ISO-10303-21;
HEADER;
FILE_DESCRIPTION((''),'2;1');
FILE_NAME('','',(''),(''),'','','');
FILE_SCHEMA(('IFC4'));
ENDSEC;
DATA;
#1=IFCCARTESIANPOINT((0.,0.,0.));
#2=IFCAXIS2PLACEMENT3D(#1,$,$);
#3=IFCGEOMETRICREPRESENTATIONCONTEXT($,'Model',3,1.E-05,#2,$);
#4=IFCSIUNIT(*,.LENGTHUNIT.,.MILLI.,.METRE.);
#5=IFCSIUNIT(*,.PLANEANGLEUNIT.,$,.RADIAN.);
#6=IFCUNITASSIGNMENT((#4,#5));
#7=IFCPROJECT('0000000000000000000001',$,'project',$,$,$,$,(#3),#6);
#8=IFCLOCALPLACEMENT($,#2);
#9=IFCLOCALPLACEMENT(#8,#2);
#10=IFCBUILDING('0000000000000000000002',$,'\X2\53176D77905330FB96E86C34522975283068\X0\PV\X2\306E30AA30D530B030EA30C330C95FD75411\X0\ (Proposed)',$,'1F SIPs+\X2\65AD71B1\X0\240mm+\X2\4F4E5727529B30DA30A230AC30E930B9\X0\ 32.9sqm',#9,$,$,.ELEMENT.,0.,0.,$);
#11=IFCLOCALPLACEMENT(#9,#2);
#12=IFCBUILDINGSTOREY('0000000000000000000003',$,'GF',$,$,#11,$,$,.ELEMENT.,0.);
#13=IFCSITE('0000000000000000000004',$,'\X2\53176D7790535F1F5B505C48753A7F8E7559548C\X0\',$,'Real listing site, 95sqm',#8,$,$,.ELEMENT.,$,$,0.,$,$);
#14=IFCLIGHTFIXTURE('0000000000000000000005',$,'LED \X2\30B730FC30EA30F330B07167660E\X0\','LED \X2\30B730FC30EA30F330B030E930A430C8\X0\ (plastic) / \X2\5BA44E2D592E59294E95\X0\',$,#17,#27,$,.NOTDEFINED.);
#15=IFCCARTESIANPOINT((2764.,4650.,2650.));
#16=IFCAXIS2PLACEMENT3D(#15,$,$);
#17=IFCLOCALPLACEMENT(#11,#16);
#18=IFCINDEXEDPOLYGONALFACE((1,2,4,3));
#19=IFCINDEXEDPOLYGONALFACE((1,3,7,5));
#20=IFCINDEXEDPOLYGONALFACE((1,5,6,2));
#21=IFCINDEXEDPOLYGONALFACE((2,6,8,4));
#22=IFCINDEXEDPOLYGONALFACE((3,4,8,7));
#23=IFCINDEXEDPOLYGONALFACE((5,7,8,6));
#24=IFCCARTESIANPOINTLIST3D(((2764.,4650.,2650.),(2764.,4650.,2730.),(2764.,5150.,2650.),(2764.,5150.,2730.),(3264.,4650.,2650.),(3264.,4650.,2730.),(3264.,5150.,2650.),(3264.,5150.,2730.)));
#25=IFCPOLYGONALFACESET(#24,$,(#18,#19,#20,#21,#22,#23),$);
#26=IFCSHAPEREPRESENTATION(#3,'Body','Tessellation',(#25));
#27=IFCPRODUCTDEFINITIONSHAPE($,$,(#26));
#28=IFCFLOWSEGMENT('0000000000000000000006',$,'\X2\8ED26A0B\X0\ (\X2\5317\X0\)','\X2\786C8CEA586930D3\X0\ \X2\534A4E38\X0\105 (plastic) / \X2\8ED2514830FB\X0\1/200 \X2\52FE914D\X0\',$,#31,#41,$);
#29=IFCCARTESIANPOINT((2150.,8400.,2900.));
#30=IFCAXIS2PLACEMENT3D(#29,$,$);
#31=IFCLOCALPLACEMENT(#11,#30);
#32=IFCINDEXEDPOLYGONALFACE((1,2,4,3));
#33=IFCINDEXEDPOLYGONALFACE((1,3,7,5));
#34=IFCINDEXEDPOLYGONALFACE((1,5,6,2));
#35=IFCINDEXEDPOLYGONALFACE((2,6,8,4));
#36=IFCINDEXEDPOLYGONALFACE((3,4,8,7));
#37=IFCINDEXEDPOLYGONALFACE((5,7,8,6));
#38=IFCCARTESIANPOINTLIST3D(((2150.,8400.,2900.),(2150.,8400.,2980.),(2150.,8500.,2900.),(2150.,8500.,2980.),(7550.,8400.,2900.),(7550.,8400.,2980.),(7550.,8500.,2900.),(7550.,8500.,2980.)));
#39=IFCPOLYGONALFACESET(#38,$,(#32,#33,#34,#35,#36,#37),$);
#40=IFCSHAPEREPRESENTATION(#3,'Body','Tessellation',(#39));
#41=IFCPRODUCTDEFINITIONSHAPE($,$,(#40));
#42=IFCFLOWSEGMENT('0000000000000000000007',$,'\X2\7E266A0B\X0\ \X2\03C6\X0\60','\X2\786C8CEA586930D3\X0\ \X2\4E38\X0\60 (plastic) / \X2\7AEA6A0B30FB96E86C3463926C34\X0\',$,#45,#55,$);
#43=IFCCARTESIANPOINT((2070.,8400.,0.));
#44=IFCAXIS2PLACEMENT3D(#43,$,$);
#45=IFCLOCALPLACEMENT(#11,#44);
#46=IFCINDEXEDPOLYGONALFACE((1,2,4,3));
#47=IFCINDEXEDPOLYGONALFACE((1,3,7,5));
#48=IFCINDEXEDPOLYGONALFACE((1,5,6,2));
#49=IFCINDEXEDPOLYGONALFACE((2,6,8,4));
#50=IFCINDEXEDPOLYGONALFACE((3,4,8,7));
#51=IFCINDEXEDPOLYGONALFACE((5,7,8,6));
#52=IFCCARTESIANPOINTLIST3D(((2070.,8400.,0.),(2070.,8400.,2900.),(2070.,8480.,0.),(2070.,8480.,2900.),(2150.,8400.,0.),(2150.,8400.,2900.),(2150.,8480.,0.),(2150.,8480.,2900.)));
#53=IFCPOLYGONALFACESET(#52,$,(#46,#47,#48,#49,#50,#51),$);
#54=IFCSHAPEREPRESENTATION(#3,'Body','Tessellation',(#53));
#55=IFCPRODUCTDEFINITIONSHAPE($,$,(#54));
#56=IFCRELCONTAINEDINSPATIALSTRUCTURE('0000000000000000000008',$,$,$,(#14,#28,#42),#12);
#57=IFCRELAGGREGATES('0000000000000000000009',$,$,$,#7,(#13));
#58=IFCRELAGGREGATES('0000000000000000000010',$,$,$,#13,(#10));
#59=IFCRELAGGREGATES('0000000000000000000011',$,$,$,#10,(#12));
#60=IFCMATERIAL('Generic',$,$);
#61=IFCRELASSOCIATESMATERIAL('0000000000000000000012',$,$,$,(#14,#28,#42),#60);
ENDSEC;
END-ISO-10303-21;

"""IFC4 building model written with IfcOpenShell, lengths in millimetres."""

from ifc_helpers import new_model, si_unit, frame, frame_2d, origin, place, context, project, spatial, rectangle, extrude, material, element, save


model = new_model("IFC4")

# Units and contexts
model_context = context("Model", 3, precision=1e-05, world=origin())
ifc_project = project(units=[si_unit("LENGTHUNIT", "METRE", prefix="MILLI"), si_unit("PLANEANGLEUNIT", "RADIAN")], contexts=[model_context])

# Site, building, storey
site_placement = place(None, origin())
site = spatial("IfcSite", under=ifc_project, at=site_placement, Name="北海道弟子屈町美留和", ObjectType="Real listing site, 95sqm", CompositionType="ELEMENT", RefElevation=0.0)
building_placement = place(site_placement, origin())
building = spatial("IfcBuilding", under=site, at=building_placement, Name="北海道・雨水利用とPVのオフグリッド志向 (Proposed)", ObjectType="1F SIPs+断熱240mm+低圧力ペアガラス 32.9sqm", CompositionType="ELEMENT", ElevationOfRefHeight=0.0, ElevationOfTerrain=0.0)
storey_placement = place(building_placement, origin())
storey = spatial("IfcBuildingStorey", under=building, at=storey_placement, Name="GF", CompositionType="ELEMENT", Elevation=0.0)

# Shared definitions
ifc_material_1 = material(Name="Generic")

# Light fixture
light_fixture_placement = place(storey_placement, frame((2764.0, 4650.0, 2650.0)))
element("IfcLightFixture", 1, at=light_fixture_placement, inside=storey, material=ifc_material_1, Name="LED シーリング照明", Description="LED シーリングライト (plastic) / 室中央天井", PredefinedType="NOTDEFINED", context=model_context, shape_type="SweptSolid", body=[
    extrude(rectangle(XDim=500.0, YDim=500.0, at=frame_2d((250.0, 250.0))), frame((2764.0, 4650.0, 2650.0)), (0.0, 0.0, 1.0), 80.0),
])

# Flow segments
flow_segment_1_placement = place(storey_placement, frame((2150.0, 8400.0, 2900.0)))
element("IfcFlowSegment", 2, at=flow_segment_1_placement, inside=storey, material=ifc_material_1, Name="軒樋 (北)", Description="硬質塩ビ 半丸105 (plastic) / 軒先・1/200 勾配", context=model_context, shape_type="SweptSolid", body=[
    extrude(rectangle(XDim=5400.0, YDim=100.0, at=frame_2d((2700.0, 50.0))), frame((2150.0, 8400.0, 2900.0)), (0.0, 0.0, 1.0), 80.0),
])
flow_segment_2_placement = place(storey_placement, frame((2070.0, 8400.0, 0.0)))
element("IfcFlowSegment", 3, at=flow_segment_2_placement, inside=storey, material=ifc_material_1, Name="縦樋 φ60", Description="硬質塩ビ 丸60 (plastic) / 竪樋・雨水排水", context=model_context, shape_type="SweptSolid", body=[
    extrude(rectangle(XDim=80.0, YDim=80.0, at=frame_2d((40.0, 40.0))), frame((2070.0, 8400.0, 0.0)), (0.0, 0.0, 1.0), 2900.0),
])

save(model, "model.ifc")
